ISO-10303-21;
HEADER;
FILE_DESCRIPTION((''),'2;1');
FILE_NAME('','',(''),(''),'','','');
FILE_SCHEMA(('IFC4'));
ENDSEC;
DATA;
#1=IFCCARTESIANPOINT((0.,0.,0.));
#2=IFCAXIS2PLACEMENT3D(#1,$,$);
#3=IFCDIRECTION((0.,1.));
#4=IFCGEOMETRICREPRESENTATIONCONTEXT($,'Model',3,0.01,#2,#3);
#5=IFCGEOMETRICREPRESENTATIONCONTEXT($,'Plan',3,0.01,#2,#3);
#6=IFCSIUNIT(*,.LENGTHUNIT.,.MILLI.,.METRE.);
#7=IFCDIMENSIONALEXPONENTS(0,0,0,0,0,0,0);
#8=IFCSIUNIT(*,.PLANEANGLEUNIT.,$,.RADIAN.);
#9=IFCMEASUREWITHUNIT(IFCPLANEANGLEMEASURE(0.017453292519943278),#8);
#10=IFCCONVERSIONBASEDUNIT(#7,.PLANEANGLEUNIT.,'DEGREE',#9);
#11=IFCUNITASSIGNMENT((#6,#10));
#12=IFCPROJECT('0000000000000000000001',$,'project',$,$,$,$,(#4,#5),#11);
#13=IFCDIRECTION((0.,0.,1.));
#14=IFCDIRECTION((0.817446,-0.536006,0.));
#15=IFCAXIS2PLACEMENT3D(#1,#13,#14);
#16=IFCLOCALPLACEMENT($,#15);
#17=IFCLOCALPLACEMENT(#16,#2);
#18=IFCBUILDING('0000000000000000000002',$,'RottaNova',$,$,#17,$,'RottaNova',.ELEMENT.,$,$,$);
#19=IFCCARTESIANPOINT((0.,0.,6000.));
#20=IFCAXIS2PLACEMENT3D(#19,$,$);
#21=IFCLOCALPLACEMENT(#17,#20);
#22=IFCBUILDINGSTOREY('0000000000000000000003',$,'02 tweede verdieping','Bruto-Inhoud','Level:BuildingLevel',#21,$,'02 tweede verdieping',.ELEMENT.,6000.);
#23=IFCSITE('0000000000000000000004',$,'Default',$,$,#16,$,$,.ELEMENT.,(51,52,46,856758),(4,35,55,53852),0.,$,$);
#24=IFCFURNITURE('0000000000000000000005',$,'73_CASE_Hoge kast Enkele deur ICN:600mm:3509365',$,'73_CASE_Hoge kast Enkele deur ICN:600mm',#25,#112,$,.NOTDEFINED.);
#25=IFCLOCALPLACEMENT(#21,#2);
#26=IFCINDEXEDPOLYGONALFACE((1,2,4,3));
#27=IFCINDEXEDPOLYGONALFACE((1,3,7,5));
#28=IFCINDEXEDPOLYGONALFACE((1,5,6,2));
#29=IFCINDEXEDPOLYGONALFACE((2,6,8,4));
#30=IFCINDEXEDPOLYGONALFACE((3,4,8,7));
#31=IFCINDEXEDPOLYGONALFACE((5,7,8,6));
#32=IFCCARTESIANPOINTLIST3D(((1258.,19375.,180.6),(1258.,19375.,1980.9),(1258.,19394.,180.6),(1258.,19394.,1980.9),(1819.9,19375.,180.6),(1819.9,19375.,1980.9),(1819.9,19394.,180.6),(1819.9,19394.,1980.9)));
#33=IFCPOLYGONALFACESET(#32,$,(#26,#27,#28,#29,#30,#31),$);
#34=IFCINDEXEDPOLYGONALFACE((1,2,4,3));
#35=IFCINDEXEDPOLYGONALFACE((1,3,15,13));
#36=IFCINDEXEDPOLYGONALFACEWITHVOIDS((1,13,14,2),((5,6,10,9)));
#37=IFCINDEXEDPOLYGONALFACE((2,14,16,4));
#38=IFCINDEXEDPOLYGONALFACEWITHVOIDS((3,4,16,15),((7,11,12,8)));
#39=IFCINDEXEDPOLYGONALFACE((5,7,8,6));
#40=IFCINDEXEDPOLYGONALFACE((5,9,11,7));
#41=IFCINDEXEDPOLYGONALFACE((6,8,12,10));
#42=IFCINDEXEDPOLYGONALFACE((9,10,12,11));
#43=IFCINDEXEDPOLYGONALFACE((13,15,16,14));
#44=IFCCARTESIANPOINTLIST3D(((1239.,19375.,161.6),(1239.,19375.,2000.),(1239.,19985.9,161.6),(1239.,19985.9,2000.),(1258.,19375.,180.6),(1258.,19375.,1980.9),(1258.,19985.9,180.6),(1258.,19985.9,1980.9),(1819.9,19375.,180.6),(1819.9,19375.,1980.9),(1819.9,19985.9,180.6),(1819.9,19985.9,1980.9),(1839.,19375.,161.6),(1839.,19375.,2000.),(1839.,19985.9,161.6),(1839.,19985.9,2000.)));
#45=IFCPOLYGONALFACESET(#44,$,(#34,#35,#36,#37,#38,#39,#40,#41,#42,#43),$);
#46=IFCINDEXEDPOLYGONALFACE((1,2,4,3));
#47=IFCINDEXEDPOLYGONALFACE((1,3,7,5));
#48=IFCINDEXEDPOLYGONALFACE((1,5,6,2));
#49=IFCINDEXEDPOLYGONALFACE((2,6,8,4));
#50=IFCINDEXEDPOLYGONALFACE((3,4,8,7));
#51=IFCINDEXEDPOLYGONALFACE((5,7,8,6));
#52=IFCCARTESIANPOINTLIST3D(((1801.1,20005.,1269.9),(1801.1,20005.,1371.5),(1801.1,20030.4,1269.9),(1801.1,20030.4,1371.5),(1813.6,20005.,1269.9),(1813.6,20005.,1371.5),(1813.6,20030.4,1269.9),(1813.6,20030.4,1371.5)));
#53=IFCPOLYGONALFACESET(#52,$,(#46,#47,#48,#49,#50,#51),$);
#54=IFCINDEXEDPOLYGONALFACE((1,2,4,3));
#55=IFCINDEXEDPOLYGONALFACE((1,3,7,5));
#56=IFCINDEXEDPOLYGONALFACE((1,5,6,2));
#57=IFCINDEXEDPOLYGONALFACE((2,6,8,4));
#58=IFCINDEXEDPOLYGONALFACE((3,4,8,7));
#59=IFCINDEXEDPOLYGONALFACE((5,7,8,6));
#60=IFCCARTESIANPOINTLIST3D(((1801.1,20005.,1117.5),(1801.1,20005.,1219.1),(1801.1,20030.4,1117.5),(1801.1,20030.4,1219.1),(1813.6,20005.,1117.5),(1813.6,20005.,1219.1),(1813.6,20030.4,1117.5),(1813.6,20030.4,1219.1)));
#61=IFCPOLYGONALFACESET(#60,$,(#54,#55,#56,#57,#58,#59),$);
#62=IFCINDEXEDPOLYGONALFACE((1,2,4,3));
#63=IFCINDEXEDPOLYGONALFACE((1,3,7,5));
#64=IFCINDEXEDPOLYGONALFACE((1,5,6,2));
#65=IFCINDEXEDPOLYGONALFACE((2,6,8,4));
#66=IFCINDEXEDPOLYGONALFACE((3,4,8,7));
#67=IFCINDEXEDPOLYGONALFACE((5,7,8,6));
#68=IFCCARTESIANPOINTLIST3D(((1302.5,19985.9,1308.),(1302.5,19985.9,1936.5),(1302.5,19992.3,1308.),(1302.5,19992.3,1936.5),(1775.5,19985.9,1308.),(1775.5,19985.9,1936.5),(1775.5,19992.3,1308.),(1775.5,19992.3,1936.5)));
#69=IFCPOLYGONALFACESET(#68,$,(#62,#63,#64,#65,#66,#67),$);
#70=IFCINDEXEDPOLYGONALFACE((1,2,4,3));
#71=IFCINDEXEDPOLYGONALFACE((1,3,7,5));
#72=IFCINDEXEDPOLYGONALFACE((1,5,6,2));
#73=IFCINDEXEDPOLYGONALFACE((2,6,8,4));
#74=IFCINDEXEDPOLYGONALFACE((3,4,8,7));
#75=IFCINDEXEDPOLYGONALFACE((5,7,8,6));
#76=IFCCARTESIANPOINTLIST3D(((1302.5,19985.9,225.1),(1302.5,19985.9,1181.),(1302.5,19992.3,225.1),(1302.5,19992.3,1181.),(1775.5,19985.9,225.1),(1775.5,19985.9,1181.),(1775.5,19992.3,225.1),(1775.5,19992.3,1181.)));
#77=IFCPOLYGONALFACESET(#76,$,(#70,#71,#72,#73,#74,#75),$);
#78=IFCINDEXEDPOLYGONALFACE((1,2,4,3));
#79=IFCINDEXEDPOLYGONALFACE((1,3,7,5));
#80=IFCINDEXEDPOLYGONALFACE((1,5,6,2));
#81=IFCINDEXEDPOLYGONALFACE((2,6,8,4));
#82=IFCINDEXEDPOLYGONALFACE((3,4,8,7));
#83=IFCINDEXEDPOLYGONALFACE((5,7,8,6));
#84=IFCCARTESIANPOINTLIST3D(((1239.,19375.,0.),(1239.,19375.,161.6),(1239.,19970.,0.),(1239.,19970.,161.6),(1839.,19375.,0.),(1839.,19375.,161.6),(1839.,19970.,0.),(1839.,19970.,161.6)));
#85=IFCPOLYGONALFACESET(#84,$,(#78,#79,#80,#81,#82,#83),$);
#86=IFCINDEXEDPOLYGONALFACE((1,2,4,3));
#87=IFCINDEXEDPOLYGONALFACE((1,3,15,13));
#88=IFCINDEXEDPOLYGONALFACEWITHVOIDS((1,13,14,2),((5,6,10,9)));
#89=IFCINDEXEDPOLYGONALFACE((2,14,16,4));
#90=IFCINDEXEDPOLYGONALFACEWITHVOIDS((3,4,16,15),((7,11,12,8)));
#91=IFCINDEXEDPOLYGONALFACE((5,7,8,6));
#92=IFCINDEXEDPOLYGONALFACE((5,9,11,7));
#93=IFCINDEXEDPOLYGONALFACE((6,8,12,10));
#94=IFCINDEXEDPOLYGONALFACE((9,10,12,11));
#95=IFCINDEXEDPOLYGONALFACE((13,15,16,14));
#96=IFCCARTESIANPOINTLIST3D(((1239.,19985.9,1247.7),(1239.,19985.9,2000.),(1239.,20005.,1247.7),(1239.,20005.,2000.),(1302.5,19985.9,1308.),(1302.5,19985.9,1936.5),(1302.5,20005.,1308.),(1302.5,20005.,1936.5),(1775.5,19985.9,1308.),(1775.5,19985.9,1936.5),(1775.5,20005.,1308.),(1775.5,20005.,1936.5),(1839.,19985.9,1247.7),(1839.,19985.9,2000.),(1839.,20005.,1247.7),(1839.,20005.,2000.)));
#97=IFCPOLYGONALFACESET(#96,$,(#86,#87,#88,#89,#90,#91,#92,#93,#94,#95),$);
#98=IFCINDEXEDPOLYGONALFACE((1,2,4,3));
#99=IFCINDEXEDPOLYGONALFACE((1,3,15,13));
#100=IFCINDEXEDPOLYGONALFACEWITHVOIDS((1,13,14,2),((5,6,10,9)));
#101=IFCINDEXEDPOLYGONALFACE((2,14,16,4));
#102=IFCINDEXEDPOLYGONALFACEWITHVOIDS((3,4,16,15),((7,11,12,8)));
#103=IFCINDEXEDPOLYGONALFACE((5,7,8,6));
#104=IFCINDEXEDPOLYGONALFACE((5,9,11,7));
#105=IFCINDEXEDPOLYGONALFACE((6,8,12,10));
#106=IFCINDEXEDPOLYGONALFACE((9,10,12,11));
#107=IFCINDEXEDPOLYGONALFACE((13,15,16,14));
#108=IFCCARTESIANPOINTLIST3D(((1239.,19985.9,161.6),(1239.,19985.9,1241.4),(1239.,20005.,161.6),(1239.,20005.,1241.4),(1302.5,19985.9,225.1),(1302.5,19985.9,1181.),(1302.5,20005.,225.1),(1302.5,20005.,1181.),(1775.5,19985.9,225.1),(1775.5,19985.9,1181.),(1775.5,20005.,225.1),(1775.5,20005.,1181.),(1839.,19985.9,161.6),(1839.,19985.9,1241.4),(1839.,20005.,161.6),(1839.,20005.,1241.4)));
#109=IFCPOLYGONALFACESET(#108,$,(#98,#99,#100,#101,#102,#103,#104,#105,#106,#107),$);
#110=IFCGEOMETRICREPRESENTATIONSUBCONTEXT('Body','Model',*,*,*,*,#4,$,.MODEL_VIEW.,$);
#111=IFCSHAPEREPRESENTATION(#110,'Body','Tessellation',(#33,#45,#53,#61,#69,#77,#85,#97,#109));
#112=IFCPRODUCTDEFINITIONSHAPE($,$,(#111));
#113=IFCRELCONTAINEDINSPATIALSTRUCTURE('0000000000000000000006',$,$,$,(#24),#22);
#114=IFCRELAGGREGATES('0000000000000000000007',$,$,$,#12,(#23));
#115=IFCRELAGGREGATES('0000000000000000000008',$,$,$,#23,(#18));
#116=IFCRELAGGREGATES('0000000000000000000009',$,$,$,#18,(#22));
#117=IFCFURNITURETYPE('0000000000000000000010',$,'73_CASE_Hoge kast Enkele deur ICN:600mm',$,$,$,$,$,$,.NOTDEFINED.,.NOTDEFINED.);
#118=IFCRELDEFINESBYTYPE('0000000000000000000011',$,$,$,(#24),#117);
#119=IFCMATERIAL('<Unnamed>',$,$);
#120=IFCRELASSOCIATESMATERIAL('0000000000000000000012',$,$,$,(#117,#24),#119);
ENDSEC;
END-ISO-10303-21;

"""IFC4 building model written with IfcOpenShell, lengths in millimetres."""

from ifc_helpers import new_model, entity, si_unit, converted_unit, direction, frame, origin, place, context, subcontext, project, spatial, indexed_curve, outline, extrude, source, transform, mapped, material, type_object, type_shapes, element, save


model = new_model("IFC4")

# Units and contexts
model_context = context("Model", 3, precision=0.01, world=origin(), true_north=direction((0.0, 1.0)))
plan_context = context("Plan", 3, precision=0.01, world=origin(), true_north=direction((0.0, 1.0)))
body_context = subcontext(model_context, "Body", "Model", "MODEL_VIEW")
ifc_project = project(units=[si_unit("LENGTHUNIT", "METRE", prefix="MILLI"), converted_unit("PLANEANGLEUNIT", "DEGREE", entity("IfcPlaneAngleMeasure", 0.017453292519943278), si_unit("PLANEANGLEUNIT", "RADIAN"), dimensions=[0, 0, 0, 0, 0, 0, 0])], contexts=[model_context, plan_context])

# Site, building, storey
site_placement = place(None, frame((0.0, 0.0, 0.0), z_axis=(0.0, 0.0, 1.0), x_axis=(0.817446, -0.536006, 0.0)))
site = spatial("IfcSite", under=ifc_project, at=site_placement, Name="Default", CompositionType="ELEMENT", RefLatitude=(51, 52, 46, 856758), RefLongitude=(4, 35, 55, 53852), RefElevation=0.0)
building_placement = place(site_placement, origin())
building = spatial("IfcBuilding", under=site, at=building_placement, Name="RottaNova", LongName="RottaNova", CompositionType="ELEMENT")
storey_placement = place(building_placement, frame((0.0, 0.0, 6000.0)))
storey = spatial("IfcBuildingStorey", under=building, at=storey_placement, Name="02 tweede verdieping", Description="Bruto-Inhoud", ObjectType="Level:BuildingLevel", LongName="02 tweede verdieping", CompositionType="ELEMENT", Elevation=6000.0)

# Furniture
ifc_material_1 = material(Name="<Unnamed>")
furniture_type = type_object("IfcFurnitureType", Name="73_CASE_Hoge kast Enkele deur ICN:600mm", AssemblyPlace="NOTDEFINED", PredefinedType="NOTDEFINED", material=ifc_material_1)
shared_shape_1 = source(origin(), body_context, "Body", "SweptSolid", [
    extrude(outline(indexed_curve([(-280.9, -9.5), (280.9, -9.5), (280.9, 9.5), (-280.9, 9.5), (-280.9, -9.5)], self_intersect=False)), frame((18.7, 9.5, 180.6), z_axis=(0.0, 0.0, 1.0), x_axis=(-1.0, 0.0, 0.0)), (0.0, 0.0, 1.0), 1800.3),
    extrude(outline(indexed_curve([(-300.0, -919.2), (300.0, -919.2), (300.0, 919.2), (-300.0, 919.2), (-300.0, -919.2)], self_intersect=False), holes=[indexed_curve([(-280.9, 900.2), (281.0, 900.2), (281.0, -900.2), (-280.9, -900.2), (-280.9, 900.2)], self_intersect=False)]), frame((18.7, 0.0, 1080.8), z_axis=(0.0, 1.0, 0.0), x_axis=(-1.0, 0.0, 0.0)), (0.0, 0.0, 1.0), 610.9),
    extrude(outline(indexed_curve([(-6.3, -12.7), (6.3, -12.7), (6.3, 12.7), (-6.3, 12.7), (-6.3, -12.7)], self_intersect=False)), frame((287.1, 642.7, 1269.9), z_axis=(0.0, 0.0, 1.0), x_axis=(-1.0, 0.0, 0.0)), (0.0, 0.0, 1.0), 101.6),
    extrude(outline(indexed_curve([(-6.3, -12.7), (6.3, -12.7), (6.3, 12.7), (-6.3, 12.7), (-6.3, -12.7)], self_intersect=False)), frame((287.1, 642.7, 1117.5), z_axis=(0.0, 0.0, 1.0), x_axis=(-1.0, 0.0, 0.0)), (0.0, 0.0, 1.0), 101.6),
    extrude(outline(indexed_curve([(-236.5, -3.2), (236.5, -3.2), (236.5, 3.2), (-236.5, 3.2), (-236.5, -3.2)], self_intersect=False)), frame((18.7, 614.1, 1308.0), z_axis=(0.0, 0.0, 1.0), x_axis=(-1.0, 0.0, 0.0)), (0.0, 0.0, 1.0), 628.5),
    extrude(outline(indexed_curve([(-236.5, -3.2), (236.5, -3.2), (236.5, 3.2), (-236.5, 3.2), (-236.5, -3.2)], self_intersect=False)), frame((18.7, 614.1, 225.1), z_axis=(0.0, 0.0, 1.0), x_axis=(-1.0, 0.0, 0.0)), (0.0, 0.0, 1.0), 956.0),
    extrude(outline(indexed_curve([(-297.5, -300.0), (297.5, -300.0), (297.5, 300.0), (-297.5, 300.0), (-297.5, -300.0)], self_intersect=False)), frame((18.7, 297.5, 0.0), z_axis=(0.0, 0.0, 1.0), x_axis=(0.0, 1.0, 0.0)), (0.0, 0.0, 1.0), 161.6),
    extrude(outline(indexed_curve([(-376.1, -300.0), (376.1, -300.0), (376.1, 300.0), (-376.1, 300.0), (-376.1, -300.0)], self_intersect=False), holes=[indexed_curve([(-312.6, -236.5), (-312.6, 236.5), (315.8, 236.5), (315.8, -236.5), (-312.6, -236.5)], self_intersect=False)]), frame((18.7, 610.9, 1623.9), z_axis=(0.0, 1.0, 0.0), x_axis=(0.0, 0.0, -1.0)), (0.0, 0.0, 1.0), 19.1),
    extrude(outline(indexed_curve([(-300.0, -539.9), (300.0, -539.9), (300.0, 539.9), (-300.0, 539.9), (-300.0, -539.9)], self_intersect=False), holes=[indexed_curve([(-236.5, 479.6), (236.5, 479.6), (236.5, -476.4), (-236.5, -476.4), (-236.5, 479.6)], self_intersect=False)]), frame((18.7, 610.9, 701.5), z_axis=(0.0, 1.0, 0.0), x_axis=(-1.0, 0.0, 0.0)), (0.0, 0.0, 1.0), 19.1),
])
type_shapes(furniture_type, [shared_shape_1])
furniture_placement = place(storey_placement, frame((1520.3, 19375.0, 0.0)))
element("IfcFurniture", 1, at=furniture_placement, inside=storey, type_object=furniture_type, material=ifc_material_1, Name="73_CASE_Hoge kast Enkele deur ICN:600mm:3509365", ObjectType="73_CASE_Hoge kast Enkele deur ICN:600mm", PredefinedType="NOTDEFINED", context=body_context, shape_type="MappedRepresentation", body=[
    mapped(shared_shape_1, transform((0.0, 0.0, 0.0), scale=1.0)),
])

save(model, "model.ifc")
